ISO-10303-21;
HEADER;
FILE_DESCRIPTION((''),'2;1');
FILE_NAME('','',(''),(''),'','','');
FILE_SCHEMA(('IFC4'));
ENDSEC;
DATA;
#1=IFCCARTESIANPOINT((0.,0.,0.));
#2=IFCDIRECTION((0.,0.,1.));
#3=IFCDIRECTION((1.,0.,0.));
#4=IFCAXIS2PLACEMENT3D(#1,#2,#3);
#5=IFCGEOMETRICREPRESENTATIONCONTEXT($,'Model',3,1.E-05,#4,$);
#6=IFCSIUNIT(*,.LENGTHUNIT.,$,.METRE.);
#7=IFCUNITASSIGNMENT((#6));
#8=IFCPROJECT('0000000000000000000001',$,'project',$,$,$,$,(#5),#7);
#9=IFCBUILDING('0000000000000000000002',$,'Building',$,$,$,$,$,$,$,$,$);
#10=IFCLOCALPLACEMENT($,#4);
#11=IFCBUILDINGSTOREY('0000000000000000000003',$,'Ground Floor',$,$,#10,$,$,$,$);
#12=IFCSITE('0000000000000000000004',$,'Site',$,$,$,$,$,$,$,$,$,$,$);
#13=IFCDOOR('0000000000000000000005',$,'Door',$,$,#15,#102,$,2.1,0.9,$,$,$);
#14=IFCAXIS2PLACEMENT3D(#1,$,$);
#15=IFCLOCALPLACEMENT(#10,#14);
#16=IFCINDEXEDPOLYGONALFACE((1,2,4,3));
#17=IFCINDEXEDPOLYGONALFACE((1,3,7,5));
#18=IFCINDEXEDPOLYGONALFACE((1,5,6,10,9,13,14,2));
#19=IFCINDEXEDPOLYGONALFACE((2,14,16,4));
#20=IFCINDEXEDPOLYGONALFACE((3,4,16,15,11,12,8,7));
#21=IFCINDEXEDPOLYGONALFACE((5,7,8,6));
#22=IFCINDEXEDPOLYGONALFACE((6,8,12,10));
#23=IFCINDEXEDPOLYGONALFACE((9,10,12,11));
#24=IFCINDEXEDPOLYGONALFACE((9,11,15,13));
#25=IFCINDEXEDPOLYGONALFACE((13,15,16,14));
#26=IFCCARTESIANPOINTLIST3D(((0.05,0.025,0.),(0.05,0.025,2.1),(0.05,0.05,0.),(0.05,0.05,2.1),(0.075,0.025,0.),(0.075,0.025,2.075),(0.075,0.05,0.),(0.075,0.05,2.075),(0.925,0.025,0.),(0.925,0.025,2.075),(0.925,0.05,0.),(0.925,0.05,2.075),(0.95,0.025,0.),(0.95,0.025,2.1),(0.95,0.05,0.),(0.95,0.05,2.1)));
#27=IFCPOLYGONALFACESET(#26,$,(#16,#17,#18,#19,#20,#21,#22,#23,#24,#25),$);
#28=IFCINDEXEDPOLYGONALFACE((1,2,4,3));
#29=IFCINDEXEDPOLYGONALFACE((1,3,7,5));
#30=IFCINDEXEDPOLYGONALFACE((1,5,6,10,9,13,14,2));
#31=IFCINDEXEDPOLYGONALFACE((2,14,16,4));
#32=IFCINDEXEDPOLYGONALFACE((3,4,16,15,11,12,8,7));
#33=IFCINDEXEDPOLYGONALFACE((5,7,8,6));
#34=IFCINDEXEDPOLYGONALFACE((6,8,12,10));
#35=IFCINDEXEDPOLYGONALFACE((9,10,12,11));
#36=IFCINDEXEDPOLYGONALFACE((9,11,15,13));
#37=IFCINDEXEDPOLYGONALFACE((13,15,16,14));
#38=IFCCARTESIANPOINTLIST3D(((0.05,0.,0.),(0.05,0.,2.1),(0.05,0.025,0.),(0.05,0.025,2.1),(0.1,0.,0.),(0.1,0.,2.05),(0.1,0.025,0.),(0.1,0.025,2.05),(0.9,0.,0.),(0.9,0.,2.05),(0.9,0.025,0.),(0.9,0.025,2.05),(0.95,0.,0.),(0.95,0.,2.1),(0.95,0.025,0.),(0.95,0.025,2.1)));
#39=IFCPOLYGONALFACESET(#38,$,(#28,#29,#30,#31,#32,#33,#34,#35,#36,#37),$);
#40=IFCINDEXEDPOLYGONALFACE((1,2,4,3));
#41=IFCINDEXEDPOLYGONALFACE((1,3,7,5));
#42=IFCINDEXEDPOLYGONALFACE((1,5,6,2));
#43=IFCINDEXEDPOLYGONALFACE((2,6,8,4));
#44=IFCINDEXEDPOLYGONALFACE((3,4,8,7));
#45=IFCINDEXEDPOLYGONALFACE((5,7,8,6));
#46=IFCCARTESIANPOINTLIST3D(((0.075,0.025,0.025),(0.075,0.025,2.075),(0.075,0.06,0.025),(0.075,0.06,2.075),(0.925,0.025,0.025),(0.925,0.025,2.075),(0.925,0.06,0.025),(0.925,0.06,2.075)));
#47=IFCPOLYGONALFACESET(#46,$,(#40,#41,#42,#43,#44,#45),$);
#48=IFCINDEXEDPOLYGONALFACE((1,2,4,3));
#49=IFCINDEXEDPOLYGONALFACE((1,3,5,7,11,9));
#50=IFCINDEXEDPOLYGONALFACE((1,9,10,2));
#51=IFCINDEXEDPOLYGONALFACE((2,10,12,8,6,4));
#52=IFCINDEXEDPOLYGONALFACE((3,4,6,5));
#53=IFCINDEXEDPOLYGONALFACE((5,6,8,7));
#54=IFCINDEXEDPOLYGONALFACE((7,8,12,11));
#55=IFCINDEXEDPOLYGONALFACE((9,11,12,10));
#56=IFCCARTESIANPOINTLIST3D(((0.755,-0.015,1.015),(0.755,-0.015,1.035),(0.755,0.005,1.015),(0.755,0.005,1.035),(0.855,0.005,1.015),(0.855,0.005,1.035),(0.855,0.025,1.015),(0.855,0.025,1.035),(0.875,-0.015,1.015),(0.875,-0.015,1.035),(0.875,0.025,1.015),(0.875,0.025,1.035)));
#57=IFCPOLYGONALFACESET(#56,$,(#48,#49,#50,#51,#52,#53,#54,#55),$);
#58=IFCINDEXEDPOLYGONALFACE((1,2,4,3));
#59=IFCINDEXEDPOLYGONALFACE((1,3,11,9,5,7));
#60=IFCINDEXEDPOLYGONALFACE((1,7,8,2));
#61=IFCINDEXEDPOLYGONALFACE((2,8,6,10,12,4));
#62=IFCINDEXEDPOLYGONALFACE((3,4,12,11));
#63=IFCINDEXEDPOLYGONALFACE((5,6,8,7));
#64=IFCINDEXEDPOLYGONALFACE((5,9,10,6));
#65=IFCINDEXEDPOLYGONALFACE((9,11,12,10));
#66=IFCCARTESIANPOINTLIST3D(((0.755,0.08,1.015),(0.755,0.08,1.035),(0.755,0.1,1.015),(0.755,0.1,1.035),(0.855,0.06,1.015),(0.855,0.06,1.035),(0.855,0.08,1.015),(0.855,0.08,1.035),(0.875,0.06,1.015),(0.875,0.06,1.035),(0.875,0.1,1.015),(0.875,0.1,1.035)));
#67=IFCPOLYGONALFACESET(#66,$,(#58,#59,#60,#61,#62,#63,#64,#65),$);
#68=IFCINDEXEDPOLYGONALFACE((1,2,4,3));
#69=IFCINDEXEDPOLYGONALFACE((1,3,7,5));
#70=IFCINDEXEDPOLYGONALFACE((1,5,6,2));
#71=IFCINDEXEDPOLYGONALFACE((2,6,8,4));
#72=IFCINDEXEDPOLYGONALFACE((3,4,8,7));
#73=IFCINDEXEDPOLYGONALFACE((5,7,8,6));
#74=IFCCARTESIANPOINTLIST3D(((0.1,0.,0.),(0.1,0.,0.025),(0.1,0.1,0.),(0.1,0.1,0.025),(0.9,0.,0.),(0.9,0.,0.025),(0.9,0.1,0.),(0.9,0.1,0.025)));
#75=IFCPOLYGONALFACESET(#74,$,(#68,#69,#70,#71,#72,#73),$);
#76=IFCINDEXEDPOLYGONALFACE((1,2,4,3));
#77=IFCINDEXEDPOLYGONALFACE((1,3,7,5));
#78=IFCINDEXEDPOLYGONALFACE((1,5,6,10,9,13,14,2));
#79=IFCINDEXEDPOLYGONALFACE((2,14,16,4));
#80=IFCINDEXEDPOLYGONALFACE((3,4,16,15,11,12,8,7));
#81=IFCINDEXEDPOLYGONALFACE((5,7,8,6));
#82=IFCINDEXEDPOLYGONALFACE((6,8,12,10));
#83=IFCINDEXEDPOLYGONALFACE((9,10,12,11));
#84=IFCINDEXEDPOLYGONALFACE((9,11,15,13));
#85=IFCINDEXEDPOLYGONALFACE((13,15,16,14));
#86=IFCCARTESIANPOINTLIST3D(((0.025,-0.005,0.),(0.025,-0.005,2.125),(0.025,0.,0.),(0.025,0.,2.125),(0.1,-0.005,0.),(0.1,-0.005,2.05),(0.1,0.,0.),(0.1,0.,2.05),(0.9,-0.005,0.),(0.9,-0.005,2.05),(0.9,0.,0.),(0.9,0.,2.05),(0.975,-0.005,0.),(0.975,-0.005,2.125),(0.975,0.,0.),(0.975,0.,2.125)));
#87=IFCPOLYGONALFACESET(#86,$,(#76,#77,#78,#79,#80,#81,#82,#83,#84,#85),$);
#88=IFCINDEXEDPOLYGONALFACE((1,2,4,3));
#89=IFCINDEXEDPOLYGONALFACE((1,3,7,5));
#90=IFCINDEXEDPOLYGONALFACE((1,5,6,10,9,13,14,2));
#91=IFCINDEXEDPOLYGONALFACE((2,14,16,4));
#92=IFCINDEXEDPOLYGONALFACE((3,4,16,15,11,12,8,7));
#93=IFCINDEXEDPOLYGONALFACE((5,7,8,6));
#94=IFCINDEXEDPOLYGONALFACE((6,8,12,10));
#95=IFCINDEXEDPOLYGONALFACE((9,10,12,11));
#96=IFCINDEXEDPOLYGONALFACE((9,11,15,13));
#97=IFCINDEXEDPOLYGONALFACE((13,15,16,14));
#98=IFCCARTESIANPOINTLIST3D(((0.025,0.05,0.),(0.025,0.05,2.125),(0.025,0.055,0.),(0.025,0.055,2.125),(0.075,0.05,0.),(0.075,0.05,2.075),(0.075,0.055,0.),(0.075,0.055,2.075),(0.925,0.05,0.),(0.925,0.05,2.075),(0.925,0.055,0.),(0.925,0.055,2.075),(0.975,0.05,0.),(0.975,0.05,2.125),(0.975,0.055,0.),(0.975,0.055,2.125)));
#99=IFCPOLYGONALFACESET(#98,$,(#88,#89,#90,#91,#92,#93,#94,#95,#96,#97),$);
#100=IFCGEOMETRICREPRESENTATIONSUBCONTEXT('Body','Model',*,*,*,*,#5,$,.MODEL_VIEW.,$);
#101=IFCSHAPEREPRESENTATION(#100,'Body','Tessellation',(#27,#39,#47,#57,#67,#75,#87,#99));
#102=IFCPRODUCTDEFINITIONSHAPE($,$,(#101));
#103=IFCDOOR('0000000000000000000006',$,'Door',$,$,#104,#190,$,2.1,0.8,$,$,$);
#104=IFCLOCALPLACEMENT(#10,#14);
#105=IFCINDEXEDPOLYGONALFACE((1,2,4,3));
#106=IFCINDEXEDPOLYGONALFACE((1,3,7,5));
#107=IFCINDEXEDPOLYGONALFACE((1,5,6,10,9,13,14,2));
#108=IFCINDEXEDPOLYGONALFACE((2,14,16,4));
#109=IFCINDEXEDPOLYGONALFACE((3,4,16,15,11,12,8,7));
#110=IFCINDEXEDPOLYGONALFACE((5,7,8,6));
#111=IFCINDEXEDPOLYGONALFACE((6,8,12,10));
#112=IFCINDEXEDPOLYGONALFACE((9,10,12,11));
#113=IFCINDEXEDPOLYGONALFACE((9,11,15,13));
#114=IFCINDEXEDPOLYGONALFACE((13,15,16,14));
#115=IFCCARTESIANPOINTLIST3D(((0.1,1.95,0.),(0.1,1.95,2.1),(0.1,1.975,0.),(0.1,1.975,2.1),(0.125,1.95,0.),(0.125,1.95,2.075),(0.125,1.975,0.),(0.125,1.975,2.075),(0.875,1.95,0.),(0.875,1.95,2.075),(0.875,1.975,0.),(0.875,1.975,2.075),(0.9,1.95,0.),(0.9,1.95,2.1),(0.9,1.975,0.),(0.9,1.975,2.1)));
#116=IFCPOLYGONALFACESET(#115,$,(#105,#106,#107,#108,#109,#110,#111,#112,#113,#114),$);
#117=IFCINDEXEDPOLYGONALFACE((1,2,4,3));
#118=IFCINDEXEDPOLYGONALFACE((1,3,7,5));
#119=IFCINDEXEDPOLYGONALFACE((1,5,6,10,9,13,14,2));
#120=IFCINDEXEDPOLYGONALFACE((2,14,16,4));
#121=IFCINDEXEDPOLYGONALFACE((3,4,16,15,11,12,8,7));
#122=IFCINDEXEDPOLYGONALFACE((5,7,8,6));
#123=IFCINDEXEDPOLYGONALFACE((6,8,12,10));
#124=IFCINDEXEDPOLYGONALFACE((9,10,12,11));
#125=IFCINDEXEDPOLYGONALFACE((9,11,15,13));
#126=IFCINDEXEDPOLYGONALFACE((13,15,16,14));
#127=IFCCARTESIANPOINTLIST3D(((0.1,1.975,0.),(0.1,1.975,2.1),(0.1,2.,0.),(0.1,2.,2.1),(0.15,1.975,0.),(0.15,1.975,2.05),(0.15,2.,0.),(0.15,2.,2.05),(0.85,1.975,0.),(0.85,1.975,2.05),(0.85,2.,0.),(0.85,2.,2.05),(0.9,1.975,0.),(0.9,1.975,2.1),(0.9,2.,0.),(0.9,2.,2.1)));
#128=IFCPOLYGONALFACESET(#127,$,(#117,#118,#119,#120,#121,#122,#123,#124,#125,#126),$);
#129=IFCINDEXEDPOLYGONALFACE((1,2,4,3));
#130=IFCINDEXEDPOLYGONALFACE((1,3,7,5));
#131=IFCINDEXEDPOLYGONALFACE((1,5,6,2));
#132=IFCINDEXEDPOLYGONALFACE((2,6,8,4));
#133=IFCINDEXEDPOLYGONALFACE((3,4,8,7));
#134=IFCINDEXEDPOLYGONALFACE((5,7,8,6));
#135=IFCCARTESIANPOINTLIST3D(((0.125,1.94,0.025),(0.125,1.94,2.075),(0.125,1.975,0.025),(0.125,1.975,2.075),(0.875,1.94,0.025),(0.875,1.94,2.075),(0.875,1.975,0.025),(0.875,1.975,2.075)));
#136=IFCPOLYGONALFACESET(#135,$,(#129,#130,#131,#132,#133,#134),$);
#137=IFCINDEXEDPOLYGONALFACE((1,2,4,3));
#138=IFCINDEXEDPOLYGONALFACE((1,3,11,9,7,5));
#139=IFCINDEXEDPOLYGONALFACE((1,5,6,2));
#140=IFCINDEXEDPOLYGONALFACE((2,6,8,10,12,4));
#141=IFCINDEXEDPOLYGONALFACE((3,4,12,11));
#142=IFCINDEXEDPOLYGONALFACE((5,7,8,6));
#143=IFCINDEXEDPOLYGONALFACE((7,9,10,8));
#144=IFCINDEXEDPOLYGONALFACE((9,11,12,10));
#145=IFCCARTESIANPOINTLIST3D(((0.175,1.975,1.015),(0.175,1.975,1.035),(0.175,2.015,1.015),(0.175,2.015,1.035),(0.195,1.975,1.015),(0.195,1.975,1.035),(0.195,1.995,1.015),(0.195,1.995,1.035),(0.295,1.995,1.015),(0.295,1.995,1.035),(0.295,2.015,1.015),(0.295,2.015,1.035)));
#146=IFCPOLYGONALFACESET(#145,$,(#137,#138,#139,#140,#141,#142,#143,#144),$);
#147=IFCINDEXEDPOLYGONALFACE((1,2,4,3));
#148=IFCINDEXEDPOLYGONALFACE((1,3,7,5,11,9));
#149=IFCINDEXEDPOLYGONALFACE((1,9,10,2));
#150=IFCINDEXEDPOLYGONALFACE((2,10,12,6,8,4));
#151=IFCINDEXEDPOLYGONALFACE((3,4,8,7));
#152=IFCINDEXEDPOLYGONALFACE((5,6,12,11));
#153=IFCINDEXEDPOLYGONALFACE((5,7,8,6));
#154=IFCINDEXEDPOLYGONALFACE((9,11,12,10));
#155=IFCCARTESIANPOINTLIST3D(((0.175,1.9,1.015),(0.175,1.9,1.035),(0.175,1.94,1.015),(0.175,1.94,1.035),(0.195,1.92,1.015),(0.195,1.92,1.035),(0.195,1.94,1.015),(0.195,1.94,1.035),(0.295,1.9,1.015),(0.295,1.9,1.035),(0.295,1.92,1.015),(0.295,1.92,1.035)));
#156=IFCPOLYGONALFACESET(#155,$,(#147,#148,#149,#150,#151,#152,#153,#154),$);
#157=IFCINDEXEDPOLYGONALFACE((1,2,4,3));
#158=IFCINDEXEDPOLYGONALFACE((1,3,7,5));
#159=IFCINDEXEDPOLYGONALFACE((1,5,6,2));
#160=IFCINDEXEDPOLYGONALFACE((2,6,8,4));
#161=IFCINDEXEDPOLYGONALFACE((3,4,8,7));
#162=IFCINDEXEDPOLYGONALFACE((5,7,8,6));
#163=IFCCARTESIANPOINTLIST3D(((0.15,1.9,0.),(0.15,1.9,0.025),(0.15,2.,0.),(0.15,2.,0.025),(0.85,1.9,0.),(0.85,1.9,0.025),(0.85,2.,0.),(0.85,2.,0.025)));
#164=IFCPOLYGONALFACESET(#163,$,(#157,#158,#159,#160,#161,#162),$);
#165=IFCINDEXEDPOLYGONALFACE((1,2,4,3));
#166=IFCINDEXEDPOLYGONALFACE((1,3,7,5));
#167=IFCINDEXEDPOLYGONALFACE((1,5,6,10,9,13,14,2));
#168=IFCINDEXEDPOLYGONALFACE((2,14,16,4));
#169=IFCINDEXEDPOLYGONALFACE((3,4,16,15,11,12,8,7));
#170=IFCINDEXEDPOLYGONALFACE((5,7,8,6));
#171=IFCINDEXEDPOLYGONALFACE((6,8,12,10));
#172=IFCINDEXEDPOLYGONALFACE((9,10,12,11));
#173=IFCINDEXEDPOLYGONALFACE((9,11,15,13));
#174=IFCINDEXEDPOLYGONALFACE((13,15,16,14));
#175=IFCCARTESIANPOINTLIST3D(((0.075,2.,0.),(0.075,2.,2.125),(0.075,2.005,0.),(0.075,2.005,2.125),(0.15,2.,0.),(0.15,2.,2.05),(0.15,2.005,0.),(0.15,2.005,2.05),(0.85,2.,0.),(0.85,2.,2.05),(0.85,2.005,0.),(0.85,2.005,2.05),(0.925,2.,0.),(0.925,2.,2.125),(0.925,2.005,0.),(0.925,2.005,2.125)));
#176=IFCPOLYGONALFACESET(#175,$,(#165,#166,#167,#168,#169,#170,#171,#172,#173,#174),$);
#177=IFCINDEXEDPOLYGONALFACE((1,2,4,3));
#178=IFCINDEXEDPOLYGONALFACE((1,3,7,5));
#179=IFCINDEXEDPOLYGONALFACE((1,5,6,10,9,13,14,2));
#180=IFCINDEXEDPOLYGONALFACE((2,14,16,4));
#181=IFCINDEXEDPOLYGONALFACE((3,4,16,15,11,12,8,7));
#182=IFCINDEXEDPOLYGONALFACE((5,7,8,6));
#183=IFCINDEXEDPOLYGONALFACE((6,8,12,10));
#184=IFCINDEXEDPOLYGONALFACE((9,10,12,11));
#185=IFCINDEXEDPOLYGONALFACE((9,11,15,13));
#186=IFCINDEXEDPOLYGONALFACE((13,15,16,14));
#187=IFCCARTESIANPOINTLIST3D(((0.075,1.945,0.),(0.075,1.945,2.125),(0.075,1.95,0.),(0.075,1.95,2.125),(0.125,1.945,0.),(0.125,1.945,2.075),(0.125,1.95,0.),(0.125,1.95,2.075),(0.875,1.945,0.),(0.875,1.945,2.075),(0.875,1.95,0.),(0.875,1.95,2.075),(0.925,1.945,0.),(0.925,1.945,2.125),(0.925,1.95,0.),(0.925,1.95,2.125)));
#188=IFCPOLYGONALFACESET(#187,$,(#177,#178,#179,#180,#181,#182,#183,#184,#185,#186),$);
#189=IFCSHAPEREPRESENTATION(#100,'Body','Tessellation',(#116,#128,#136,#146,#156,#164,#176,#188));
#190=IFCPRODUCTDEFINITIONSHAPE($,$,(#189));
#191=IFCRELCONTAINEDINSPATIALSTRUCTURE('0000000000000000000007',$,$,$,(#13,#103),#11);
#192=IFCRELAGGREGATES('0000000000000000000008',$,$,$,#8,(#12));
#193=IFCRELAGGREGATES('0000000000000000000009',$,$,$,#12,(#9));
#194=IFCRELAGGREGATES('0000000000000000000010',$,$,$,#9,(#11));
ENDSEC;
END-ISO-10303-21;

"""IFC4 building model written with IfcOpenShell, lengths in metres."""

from ifc_helpers import new_model, si_unit, frame, origin_with_axes, place, context, subcontext, project, spatial, line, indexed_curve, outline, extrude, element, save


model = new_model("IFC4")

# Units and contexts
model_context = context("Model", 3, precision=1e-05, world=origin_with_axes())
body_context = subcontext(model_context, "Body", "Model", "MODEL_VIEW")
ifc_project = project(units=[si_unit("LENGTHUNIT", "METRE")], contexts=[model_context])

# Site, building, storey
site = spatial("IfcSite", under=ifc_project, Name="Site")
building = spatial("IfcBuilding", under=site, Name="Building")
storey_placement = place(None, origin_with_axes())
storey = spatial("IfcBuildingStorey", under=building, at=storey_placement, Name="Ground Floor")

# Doors
door_1_placement = place(storey_placement, frame((0.05, 0.0, 0.0), z_axis=(0.0, 0.0, 1.0), x_axis=(1.0, 0.0, 0.0)))
element("IfcDoor", 1, at=door_1_placement, inside=storey, Name="Door", OverallHeight=2.1, OverallWidth=0.9, context=body_context, shape_type="SweptSolid", body=[
    extrude(outline(indexed_curve([(0.0, 0.0), (0.0, 2.1), (0.9, 2.1), (0.9, 0.0), (0.875, 0.0), (0.875, 2.075), (0.025, 2.075), (0.025, 0.0)], segments=[line(1, 2, 3, 4, 5, 6, 7, 8, 1)])), frame((0.0, 0.025, 0.0), z_axis=(0.0, -1.0, 0.0), x_axis=(1.0, 0.0, 0.0)), (0.0, 0.0, -1.0), 0.025),
    extrude(outline(indexed_curve([(0.0, 0.0), (0.0, 2.1), (0.9, 2.1), (0.9, 0.0), (0.85, 0.0), (0.85, 2.05), (0.05, 2.05), (0.05, 0.0)], segments=[line(1, 2, 3, 4, 5, 6, 7, 8, 1)])), frame((0.0, 0.0, 0.0), z_axis=(0.0, -1.0, 0.0), x_axis=(1.0, 0.0, 0.0)), (0.0, 0.0, -1.0), 0.025),
    extrude(outline(indexed_curve([(0.0, 0.0), (0.85, 0.0), (0.85, 0.035), (0.0, 0.035)], segments=[line(1, 2, 3, 4, 1)])), frame((0.025, 0.025, 0.025), z_axis=(0.0, 0.0, 1.0), x_axis=(1.0, 0.0, 0.0)), (0.0, 0.0, 1.0), 2.05),
    extrude(outline(indexed_curve([(0.0, 0.0), (0.0, -0.04), (-0.12, -0.04), (-0.12, -0.02), (-0.02, -0.02), (-0.02, 0.0)], segments=[line(1, 2, 3, 4, 5, 6, 1)])), frame((0.825, 0.025, 1.015), z_axis=(0.0, 0.0, 1.0), x_axis=(1.0, 0.0, 0.0)), (0.0, 0.0, 1.0), 0.02),
    extrude(outline(indexed_curve([(0.0, 0.0), (0.0, 0.04), (-0.12, 0.04), (-0.12, 0.02), (-0.02, 0.02), (-0.02, 0.0)], segments=[line(1, 2, 3, 4, 5, 6, 1)])), frame((0.825, 0.06, 1.015), z_axis=(0.0, 0.0, 1.0), x_axis=(1.0, 0.0, 0.0)), (0.0, 0.0, 1.0), 0.02),
    extrude(outline(indexed_curve([(0.0, 0.0), (0.8, 0.0), (0.8, 0.1), (0.0, 0.1)], segments=[line(1, 2, 3, 4, 1)])), frame((0.05, 0.0, 0.0), z_axis=(0.0, 0.0, 1.0), x_axis=(1.0, 0.0, 0.0)), (0.0, 0.0, 1.0), 0.025),
    extrude(outline(indexed_curve([(0.0, 0.0), (0.0, 2.125), (0.95, 2.125), (0.95, 0.0), (0.875, 0.0), (0.875, 2.05), (0.075, 2.05), (0.075, 0.0)], segments=[line(1, 2, 3, 4, 5, 6, 7, 8, 1)])), frame((-0.025, -0.005, 0.0), z_axis=(0.0, -1.0, 0.0), x_axis=(1.0, 0.0, 0.0)), (0.0, 0.0, -1.0), 0.005),
    extrude(outline(indexed_curve([(0.0, 0.0), (0.0, 2.125), (0.95, 2.125), (0.95, 0.0), (0.9, 0.0), (0.9, 2.075), (0.05, 2.075), (0.05, 0.0)], segments=[line(1, 2, 3, 4, 5, 6, 7, 8, 1)])), frame((-0.025, 0.05, 0.0), z_axis=(0.0, -1.0, 0.0), x_axis=(1.0, 0.0, 0.0)), (0.0, 0.0, -1.0), 0.005),
])
door_2_placement = place(storey_placement, frame((0.9, 2.0, 0.0), z_axis=(0.0, 0.0, 1.0), x_axis=(-1.0, 0.0, 0.0)))
element("IfcDoor", 2, at=door_2_placement, inside=storey, Name="Door", OverallHeight=2.1, OverallWidth=0.8, context=body_context, shape_type="SweptSolid", body=[
    extrude(outline(indexed_curve([(0.0, 0.0), (0.0, 2.1), (0.8, 2.1), (0.8, 0.0), (0.775, 0.0), (0.775, 2.075), (0.025, 2.075), (0.025, 0.0)], segments=[line(1, 2, 3, 4, 5, 6, 7, 8, 1)])), frame((0.0, 0.025, 0.0), z_axis=(0.0, -1.0, 0.0), x_axis=(1.0, 0.0, 0.0)), (0.0, 0.0, -1.0), 0.025),
    extrude(outline(indexed_curve([(0.0, 0.0), (0.0, 2.1), (0.8, 2.1), (0.8, 0.0), (0.75, 0.0), (0.75, 2.05), (0.05, 2.05), (0.05, 0.0)], segments=[line(1, 2, 3, 4, 5, 6, 7, 8, 1)])), frame((0.0, 0.0, 0.0), z_axis=(0.0, -1.0, 0.0), x_axis=(1.0, 0.0, 0.0)), (0.0, 0.0, -1.0), 0.025),
    extrude(outline(indexed_curve([(0.0, 0.0), (0.75, 0.0), (0.75, 0.035), (0.0, 0.035)], segments=[line(1, 2, 3, 4, 1)])), frame((0.025, 0.025, 0.025), z_axis=(0.0, 0.0, 1.0), x_axis=(1.0, 0.0, 0.0)), (0.0, 0.0, 1.0), 2.05),
    extrude(outline(indexed_curve([(0.0, 0.0), (0.0, -0.04), (-0.12, -0.04), (-0.12, -0.02), (-0.02, -0.02), (-0.02, 0.0)], segments=[line(1, 2, 3, 4, 5, 6, 1)])), frame((0.725, 0.025, 1.015), z_axis=(0.0, 0.0, 1.0), x_axis=(1.0, 0.0, 0.0)), (0.0, 0.0, 1.0), 0.02),
    extrude(outline(indexed_curve([(0.0, 0.0), (0.0, 0.04), (-0.12, 0.04), (-0.12, 0.02), (-0.02, 0.02), (-0.02, 0.0)], segments=[line(1, 2, 3, 4, 5, 6, 1)])), frame((0.725, 0.06, 1.015), z_axis=(0.0, 0.0, 1.0), x_axis=(1.0, 0.0, 0.0)), (0.0, 0.0, 1.0), 0.02),
    extrude(outline(indexed_curve([(0.0, 0.0), (0.7, 0.0), (0.7, 0.1), (0.0, 0.1)], segments=[line(1, 2, 3, 4, 1)])), frame((0.05, 0.0, 0.0), z_axis=(0.0, 0.0, 1.0), x_axis=(1.0, 0.0, 0.0)), (0.0, 0.0, 1.0), 0.025),
    extrude(outline(indexed_curve([(0.0, 0.0), (0.0, 2.125), (0.85, 2.125), (0.85, 0.0), (0.775, 0.0), (0.775, 2.05), (0.075, 2.05), (0.075, 0.0)], segments=[line(1, 2, 3, 4, 5, 6, 7, 8, 1)])), frame((-0.025, -0.005, 0.0), z_axis=(0.0, -1.0, 0.0), x_axis=(1.0, 0.0, 0.0)), (0.0, 0.0, -1.0), 0.005),
    extrude(outline(indexed_curve([(0.0, 0.0), (0.0, 2.125), (0.85, 2.125), (0.85, 0.0), (0.8, 0.0), (0.8, 2.075), (0.05, 2.075), (0.05, 0.0)], segments=[line(1, 2, 3, 4, 5, 6, 7, 8, 1)])), frame((-0.025, 0.05, 0.0), z_axis=(0.0, -1.0, 0.0), x_axis=(1.0, 0.0, 0.0)), (0.0, 0.0, -1.0), 0.005),
])

save(model, "model.ifc")
